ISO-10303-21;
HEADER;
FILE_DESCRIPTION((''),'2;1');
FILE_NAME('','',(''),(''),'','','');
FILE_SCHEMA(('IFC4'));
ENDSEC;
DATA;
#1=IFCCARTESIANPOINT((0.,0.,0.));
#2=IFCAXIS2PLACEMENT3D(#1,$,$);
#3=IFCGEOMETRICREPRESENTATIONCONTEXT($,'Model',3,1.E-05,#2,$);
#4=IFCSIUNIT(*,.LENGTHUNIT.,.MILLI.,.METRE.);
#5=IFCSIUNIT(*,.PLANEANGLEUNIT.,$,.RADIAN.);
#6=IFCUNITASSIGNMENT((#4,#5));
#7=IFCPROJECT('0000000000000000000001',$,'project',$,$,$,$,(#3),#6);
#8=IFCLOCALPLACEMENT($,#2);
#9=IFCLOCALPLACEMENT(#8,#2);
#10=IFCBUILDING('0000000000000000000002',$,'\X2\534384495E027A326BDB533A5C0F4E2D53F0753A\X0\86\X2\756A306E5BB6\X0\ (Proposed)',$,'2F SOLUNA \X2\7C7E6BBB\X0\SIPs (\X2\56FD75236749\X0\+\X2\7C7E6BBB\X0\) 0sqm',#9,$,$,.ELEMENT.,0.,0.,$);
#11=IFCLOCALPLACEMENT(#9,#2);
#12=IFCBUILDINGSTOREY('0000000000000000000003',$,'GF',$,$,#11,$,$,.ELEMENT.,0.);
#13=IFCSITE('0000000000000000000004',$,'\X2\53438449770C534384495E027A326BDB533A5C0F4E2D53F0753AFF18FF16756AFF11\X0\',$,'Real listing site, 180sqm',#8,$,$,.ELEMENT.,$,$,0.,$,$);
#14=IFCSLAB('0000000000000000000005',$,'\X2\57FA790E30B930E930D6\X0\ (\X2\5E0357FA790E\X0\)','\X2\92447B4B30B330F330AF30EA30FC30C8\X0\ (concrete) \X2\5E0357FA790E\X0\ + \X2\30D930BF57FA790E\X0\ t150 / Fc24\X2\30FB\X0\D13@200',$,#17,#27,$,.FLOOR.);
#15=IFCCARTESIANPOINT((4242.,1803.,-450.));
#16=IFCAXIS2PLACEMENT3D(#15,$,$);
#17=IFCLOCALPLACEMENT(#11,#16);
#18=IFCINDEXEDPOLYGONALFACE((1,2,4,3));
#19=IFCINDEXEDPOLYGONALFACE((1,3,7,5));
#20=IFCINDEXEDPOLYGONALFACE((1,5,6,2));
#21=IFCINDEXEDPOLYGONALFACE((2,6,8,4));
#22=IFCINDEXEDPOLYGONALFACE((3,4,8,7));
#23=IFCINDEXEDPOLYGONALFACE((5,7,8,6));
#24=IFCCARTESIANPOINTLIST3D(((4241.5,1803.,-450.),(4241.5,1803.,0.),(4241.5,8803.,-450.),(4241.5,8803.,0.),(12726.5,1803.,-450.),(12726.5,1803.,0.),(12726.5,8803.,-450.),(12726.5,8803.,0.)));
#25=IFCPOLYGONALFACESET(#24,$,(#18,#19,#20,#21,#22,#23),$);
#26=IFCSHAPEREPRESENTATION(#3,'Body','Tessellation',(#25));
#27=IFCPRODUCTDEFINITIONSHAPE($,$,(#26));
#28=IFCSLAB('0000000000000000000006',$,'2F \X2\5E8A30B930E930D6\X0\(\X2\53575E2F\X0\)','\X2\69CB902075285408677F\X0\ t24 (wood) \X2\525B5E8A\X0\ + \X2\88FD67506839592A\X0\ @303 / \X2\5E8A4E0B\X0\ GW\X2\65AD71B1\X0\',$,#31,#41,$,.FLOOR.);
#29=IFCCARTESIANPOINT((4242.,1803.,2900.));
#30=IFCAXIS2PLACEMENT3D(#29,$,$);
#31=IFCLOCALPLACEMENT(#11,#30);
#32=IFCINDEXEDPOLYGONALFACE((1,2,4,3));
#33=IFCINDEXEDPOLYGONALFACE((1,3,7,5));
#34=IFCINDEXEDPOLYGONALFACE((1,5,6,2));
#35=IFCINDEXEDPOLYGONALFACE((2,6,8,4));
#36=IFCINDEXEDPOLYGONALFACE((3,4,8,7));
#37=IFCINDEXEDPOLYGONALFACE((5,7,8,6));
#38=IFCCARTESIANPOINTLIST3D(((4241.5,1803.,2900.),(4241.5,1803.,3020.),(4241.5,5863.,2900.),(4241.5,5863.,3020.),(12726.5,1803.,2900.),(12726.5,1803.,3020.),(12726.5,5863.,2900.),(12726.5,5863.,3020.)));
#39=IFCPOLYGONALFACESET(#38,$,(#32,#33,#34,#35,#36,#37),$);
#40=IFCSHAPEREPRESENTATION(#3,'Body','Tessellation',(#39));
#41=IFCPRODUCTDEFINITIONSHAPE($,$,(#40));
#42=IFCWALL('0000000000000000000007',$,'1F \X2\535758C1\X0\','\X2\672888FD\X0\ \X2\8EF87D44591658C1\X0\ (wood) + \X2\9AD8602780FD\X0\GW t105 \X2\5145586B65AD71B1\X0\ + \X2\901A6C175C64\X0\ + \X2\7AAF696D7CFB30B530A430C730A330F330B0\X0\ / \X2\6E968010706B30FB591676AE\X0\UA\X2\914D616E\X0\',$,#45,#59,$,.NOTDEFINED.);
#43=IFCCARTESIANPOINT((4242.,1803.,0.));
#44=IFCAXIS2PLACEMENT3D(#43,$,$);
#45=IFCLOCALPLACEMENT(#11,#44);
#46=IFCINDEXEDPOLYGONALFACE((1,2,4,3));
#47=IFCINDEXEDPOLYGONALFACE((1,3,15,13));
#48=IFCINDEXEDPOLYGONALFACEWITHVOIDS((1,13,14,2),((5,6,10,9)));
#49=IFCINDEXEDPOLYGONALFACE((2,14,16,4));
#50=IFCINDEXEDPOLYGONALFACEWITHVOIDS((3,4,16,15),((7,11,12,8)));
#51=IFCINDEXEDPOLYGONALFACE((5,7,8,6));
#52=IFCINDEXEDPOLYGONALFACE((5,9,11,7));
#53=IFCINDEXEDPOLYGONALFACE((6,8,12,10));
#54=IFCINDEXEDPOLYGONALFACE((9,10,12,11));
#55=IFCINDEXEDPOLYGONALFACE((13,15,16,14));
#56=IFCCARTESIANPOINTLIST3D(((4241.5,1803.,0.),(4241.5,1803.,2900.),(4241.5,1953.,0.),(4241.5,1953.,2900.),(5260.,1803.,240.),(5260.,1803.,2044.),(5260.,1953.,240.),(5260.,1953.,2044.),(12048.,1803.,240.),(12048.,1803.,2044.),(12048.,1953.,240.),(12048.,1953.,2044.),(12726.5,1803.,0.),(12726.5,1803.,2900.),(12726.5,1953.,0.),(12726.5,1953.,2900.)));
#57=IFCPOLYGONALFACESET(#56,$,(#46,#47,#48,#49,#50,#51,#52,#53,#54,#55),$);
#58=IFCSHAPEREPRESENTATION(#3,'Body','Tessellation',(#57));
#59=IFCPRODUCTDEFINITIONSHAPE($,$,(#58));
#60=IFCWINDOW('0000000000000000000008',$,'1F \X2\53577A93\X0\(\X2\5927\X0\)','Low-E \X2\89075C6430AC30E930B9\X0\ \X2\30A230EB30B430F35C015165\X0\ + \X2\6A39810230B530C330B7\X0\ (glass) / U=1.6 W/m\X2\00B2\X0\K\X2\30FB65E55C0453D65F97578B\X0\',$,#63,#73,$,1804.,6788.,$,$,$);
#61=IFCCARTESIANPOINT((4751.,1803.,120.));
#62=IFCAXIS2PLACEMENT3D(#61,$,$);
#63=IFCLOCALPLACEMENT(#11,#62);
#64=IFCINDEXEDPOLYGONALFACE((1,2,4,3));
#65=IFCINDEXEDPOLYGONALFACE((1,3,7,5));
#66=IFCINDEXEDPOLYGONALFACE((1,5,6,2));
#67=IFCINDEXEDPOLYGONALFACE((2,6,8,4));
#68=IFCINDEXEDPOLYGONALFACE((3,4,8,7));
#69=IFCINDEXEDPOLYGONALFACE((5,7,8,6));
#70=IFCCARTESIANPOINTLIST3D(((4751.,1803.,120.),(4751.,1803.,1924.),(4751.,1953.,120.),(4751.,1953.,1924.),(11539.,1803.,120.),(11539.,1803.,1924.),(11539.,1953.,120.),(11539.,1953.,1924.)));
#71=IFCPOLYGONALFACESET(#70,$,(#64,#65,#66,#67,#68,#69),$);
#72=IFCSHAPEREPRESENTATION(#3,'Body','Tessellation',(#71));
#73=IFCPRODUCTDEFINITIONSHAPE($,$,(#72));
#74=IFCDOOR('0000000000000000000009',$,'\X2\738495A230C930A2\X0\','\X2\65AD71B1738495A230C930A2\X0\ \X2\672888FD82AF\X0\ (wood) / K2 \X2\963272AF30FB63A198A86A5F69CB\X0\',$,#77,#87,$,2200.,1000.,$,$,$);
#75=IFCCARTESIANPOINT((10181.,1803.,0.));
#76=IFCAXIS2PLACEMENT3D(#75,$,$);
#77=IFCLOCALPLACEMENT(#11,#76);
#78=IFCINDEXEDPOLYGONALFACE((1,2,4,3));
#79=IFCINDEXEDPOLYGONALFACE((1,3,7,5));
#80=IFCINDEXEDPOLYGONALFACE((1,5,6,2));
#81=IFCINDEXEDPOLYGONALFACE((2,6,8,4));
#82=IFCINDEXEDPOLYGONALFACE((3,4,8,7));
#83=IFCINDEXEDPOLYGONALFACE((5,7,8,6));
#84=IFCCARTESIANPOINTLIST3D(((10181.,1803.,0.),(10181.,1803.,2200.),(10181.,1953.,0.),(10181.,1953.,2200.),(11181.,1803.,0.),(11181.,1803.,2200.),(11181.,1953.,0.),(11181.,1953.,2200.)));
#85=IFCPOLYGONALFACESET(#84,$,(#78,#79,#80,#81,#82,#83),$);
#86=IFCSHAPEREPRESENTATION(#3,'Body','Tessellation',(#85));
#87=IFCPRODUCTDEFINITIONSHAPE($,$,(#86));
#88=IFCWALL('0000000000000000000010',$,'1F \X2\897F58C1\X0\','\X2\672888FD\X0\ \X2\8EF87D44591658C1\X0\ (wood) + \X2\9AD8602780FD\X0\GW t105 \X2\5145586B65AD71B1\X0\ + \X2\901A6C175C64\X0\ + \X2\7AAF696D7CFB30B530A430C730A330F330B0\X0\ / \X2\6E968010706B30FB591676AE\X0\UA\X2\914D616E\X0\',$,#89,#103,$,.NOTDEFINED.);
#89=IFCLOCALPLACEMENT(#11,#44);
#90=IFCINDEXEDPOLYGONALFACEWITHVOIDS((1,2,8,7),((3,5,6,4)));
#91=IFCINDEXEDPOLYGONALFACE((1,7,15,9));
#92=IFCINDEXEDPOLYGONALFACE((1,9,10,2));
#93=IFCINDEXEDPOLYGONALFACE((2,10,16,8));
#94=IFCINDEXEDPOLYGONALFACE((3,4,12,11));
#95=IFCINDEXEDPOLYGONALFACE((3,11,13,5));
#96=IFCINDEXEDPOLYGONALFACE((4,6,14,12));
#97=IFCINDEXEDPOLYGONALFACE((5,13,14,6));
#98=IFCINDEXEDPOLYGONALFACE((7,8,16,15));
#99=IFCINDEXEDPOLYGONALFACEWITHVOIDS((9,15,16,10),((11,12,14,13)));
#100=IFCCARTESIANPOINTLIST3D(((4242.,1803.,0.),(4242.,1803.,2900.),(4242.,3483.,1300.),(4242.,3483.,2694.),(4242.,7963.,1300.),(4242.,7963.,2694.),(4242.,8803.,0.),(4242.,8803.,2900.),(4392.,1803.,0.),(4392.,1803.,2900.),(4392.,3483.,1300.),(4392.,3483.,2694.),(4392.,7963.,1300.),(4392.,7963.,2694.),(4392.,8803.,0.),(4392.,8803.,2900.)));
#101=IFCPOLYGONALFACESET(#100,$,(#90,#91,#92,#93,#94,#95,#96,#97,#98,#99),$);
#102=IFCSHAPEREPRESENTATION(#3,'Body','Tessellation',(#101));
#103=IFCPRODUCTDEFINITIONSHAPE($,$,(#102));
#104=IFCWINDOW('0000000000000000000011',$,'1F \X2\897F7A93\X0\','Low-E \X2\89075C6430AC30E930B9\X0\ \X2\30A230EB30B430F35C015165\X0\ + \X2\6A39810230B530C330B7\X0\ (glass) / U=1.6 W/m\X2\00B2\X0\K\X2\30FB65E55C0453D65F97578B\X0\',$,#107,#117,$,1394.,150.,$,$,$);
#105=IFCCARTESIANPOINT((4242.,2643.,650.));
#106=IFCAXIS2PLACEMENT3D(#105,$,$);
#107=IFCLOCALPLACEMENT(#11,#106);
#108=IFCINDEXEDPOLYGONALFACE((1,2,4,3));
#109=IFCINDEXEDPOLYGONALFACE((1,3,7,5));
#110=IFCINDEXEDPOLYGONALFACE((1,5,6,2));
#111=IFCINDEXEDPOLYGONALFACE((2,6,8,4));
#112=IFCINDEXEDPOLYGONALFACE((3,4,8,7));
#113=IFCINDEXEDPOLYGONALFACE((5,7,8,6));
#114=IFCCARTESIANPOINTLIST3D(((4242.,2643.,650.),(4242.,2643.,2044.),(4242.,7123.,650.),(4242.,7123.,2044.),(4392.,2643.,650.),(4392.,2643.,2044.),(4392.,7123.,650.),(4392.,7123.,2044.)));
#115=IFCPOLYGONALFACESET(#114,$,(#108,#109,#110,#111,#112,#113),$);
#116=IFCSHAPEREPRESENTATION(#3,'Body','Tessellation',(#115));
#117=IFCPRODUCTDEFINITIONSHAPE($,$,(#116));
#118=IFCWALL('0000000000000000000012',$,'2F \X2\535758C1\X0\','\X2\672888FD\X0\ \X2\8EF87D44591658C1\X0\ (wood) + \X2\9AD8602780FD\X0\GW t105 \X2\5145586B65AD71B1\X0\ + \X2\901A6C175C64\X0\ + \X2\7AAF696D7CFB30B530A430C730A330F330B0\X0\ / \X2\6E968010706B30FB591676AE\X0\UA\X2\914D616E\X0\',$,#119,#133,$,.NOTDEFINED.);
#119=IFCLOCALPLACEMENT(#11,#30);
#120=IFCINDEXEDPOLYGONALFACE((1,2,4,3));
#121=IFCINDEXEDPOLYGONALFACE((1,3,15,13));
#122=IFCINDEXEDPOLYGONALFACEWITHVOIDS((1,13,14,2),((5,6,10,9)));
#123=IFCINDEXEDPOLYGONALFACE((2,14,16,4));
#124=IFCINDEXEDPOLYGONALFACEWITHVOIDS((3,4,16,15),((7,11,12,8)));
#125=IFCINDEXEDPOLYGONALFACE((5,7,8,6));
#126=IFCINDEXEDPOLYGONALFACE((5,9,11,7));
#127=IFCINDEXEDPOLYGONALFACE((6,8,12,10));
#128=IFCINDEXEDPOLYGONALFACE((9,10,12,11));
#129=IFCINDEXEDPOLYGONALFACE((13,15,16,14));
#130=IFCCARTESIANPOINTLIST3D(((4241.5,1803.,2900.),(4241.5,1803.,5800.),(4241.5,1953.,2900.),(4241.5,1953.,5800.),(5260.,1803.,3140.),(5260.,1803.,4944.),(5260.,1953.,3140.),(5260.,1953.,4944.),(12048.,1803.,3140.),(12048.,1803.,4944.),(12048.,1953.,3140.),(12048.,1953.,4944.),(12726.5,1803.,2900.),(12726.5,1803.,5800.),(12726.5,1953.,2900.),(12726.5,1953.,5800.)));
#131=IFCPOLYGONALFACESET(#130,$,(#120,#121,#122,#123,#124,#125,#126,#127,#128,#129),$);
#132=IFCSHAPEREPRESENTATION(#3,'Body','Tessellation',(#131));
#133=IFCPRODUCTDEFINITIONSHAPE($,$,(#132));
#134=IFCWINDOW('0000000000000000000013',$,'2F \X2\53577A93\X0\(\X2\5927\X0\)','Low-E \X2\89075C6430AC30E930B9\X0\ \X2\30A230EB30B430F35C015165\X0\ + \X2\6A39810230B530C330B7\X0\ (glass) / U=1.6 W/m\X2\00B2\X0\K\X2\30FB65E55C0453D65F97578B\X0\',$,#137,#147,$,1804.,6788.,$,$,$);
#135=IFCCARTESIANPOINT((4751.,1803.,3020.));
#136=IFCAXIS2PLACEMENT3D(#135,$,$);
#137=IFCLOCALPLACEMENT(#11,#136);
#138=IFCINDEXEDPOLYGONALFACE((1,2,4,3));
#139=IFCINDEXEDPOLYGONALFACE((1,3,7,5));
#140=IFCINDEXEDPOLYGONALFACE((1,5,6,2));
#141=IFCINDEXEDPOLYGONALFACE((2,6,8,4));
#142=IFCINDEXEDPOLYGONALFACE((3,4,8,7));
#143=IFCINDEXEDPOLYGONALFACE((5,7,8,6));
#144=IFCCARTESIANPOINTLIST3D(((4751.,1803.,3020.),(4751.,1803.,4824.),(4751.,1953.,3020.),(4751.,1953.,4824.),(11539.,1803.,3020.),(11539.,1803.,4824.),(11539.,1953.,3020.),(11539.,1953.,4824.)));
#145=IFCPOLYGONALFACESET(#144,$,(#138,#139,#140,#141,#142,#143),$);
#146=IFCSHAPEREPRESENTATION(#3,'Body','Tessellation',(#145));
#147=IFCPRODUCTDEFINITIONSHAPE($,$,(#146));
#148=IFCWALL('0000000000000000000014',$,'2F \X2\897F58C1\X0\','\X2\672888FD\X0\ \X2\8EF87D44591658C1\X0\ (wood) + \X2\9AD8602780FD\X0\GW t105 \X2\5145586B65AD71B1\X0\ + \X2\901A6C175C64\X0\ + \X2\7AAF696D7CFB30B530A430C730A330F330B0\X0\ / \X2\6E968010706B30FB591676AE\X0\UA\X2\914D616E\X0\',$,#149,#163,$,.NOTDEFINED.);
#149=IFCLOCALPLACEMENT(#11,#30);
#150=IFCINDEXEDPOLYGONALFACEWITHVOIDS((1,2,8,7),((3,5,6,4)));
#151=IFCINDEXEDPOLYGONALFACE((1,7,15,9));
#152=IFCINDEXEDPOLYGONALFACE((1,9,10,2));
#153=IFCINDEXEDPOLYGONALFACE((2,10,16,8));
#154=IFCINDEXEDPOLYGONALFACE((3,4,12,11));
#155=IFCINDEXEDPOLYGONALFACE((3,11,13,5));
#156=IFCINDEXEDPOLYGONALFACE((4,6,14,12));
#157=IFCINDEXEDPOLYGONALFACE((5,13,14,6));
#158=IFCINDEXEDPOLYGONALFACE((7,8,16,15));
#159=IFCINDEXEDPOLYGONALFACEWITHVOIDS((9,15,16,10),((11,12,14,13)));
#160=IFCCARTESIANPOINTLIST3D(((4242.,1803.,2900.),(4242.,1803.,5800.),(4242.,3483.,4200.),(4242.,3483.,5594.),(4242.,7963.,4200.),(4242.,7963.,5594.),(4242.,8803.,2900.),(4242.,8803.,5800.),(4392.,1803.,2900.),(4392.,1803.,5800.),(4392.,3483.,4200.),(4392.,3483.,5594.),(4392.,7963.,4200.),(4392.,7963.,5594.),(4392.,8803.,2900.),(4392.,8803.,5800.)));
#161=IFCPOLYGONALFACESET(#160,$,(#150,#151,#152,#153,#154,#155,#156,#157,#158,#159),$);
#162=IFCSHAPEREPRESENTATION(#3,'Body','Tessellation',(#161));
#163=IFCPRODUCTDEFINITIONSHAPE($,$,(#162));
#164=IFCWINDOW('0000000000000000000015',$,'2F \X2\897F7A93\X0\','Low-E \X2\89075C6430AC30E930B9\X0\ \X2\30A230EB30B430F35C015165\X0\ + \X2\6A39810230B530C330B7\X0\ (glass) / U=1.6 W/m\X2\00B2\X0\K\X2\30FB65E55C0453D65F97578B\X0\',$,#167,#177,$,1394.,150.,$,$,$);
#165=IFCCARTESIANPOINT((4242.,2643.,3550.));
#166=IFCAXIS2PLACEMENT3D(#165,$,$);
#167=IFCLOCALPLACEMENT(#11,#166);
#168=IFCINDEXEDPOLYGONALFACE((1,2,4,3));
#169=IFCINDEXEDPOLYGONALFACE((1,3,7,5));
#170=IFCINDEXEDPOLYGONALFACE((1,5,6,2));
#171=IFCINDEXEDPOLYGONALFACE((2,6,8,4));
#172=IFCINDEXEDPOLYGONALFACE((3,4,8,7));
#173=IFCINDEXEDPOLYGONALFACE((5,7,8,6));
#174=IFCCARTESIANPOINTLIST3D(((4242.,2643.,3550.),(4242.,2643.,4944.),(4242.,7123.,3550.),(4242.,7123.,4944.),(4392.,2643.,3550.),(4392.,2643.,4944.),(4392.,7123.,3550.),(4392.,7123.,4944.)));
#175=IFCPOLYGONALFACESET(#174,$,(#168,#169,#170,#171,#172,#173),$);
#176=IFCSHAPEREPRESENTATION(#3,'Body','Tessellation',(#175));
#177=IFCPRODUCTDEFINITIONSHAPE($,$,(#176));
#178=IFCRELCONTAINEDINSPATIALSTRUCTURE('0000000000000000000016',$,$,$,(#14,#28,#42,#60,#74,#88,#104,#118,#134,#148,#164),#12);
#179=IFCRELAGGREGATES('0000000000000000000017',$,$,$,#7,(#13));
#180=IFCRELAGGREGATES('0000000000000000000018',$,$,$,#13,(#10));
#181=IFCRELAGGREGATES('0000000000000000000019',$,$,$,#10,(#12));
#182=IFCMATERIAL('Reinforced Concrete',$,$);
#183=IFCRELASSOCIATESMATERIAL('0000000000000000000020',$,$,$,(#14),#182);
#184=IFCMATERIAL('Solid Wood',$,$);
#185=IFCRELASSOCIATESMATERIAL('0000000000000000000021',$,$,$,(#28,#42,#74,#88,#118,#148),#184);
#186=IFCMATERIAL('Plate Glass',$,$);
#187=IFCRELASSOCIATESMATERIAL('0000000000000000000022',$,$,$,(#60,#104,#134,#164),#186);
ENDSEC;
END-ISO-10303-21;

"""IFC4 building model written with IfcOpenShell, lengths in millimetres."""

from ifc_helpers import new_model, si_unit, frame, frame_2d, origin, place, context, project, spatial, rectangle, extrude, material, element, fill, save


model = new_model("IFC4")

# Units and contexts
model_context = context("Model", 3, precision=1e-05, world=origin())
ifc_project = project(units=[si_unit("LENGTHUNIT", "METRE", prefix="MILLI"), si_unit("PLANEANGLEUNIT", "RADIAN")], contexts=[model_context])

# Site, building, storey
site_placement = place(None, origin())
site = spatial("IfcSite", under=ifc_project, at=site_placement, Name="千葉県千葉市稲毛区小中台町８６番１", ObjectType="Real listing site, 180sqm", CompositionType="ELEMENT", RefElevation=0.0)
building_placement = place(site_placement, origin())
building = spatial("IfcBuilding", under=site, at=building_placement, Name="千葉市稲毛区小中台町86番の家 (Proposed)", ObjectType="2F SOLUNA 籾殻SIPs (国産杉+籾殻) 0sqm", CompositionType="ELEMENT", ElevationOfRefHeight=0.0, ElevationOfTerrain=0.0)
storey_placement = place(building_placement, origin())
storey = spatial("IfcBuildingStorey", under=building, at=storey_placement, Name="GF", CompositionType="ELEMENT", Elevation=0.0)

# Slabs
ifc_material_1 = material(Name="Reinforced Concrete")
slab_1_placement = place(storey_placement, frame((4242.0, 1803.0, -450.0)))
element("IfcSlab", 1, at=slab_1_placement, inside=storey, material=ifc_material_1, Name="基礎スラブ (布基礎)", Description="鉄筋コンクリート (concrete) 布基礎 + ベタ基礎 t150 / Fc24・D13@200", PredefinedType="FLOOR", context=model_context, shape_type="SweptSolid", body=[
    extrude(rectangle(XDim=8485.0, YDim=7000.0, at=frame_2d((4242.0, 3500.0))), frame((4242.0, 1803.0, -450.0)), (0.0, 0.0, 1.0), 450.0),
])
ifc_material_2 = material(Name="Solid Wood")
slab_2_placement = place(storey_placement, frame((4242.0, 1803.0, 2900.0)))
element("IfcSlab", 2, at=slab_2_placement, inside=storey, material=ifc_material_2, Name="2F 床スラブ(南帯)", Description="構造用合板 t24 (wood) 剛床 + 製材根太 @303 / 床下 GW断熱", PredefinedType="FLOOR", context=model_context, shape_type="SweptSolid", body=[
    extrude(rectangle(XDim=8485.0, YDim=4060.0, at=frame_2d((4242.0, 2030.0))), frame((4242.0, 1803.0, 2900.0)), (0.0, 0.0, 1.0), 120.0),
])

# Wall, openings, window, door
wall_1_placement = place(storey_placement, frame((4242.0, 1803.0, 0.0)))
wall_1 = element("IfcWall", 3, at=wall_1_placement, inside=storey, material=ifc_material_2, Name="1F 南壁", Description="木製 軸組外壁 (wood) + 高性能GW t105 充填断熱 + 通気層 + 窯業系サイディング / 準耐火・外皮UA配慮", PredefinedType="NOTDEFINED", context=model_context, shape_type="SweptSolid", body=[
    extrude(rectangle(XDim=8485.0, YDim=150.0, at=frame_2d((4242.0, 75.0))), frame((4242.0, 1803.0, 0.0)), (0.0, 0.0, 1.0), 2900.0),
])
opening_1_placement = place(storey_placement, frame((4751.0, 1803.0, 120.0)))
opening_1 = element("IfcOpeningElement", 4, at=opening_1_placement, cuts=wall_1, PredefinedType="NOTDEFINED", context=model_context, shape_type="SweptSolid", body=[
    extrude(rectangle(XDim=6788.0, YDim=150.0, at=frame_2d((3394.0, 75.0))), frame((4751.0, 1803.0, 120.0)), (0.0, 0.0, 1.0), 1804.0),
])
opening_2_placement = place(storey_placement, frame((10181.0, 1803.0, 0.0)))
opening_2 = element("IfcOpeningElement", 5, at=opening_2_placement, cuts=wall_1, PredefinedType="NOTDEFINED", context=model_context, shape_type="SweptSolid", body=[
    extrude(rectangle(XDim=1000.0, YDim=150.0, at=frame_2d((500.0, 75.0))), frame((10181.0, 1803.0, 0.0)), (0.0, 0.0, 1.0), 2200.0),
])
ifc_material_3 = material(Name="Plate Glass")
window_1_placement = place(storey_placement, frame((4751.0, 1803.0, 120.0)))
window_1 = element("IfcWindow", 6, at=window_1_placement, inside=storey, material=ifc_material_3, Name="1F 南窓(大)", Description="Low-E 複層ガラス アルゴン封入 + 樹脂サッシ (glass) / U=1.6 W/m²K・日射取得型", OverallHeight=1804.0, OverallWidth=6788.0, context=model_context, shape_type="SweptSolid", body=[
    extrude(rectangle(XDim=6788.0, YDim=150.0, at=frame_2d((3394.0, 75.0))), frame((4751.0, 1803.0, 120.0)), (0.0, 0.0, 1.0), 1804.0),
])
fill(opening_1, window_1)
door_placement = place(storey_placement, frame((10181.0, 1803.0, 0.0)))
door = element("IfcDoor", 7, at=door_placement, inside=storey, material=ifc_material_2, Name="玄関ドア", Description="断熱玄関ドア 木製芯 (wood) / K2 防犯・採風機構", OverallHeight=2200.0, OverallWidth=1000.0, context=model_context, shape_type="SweptSolid", body=[
    extrude(rectangle(XDim=1000.0, YDim=150.0, at=frame_2d((500.0, 75.0))), frame((10181.0, 1803.0, 0.0)), (0.0, 0.0, 1.0), 2200.0),
])
fill(opening_2, door)

# Wall, opening, window
wall_2_placement = place(storey_placement, frame((4242.0, 1803.0, 0.0)))
wall_2 = element("IfcWall", 8, at=wall_2_placement, inside=storey, material=ifc_material_2, Name="1F 西壁", Description="木製 軸組外壁 (wood) + 高性能GW t105 充填断熱 + 通気層 + 窯業系サイディング / 準耐火・外皮UA配慮", PredefinedType="NOTDEFINED", context=model_context, shape_type="SweptSolid", body=[
    extrude(rectangle(XDim=150.0, YDim=7000.0, at=frame_2d((75.0, 3500.0))), frame((4242.0, 1803.0, 0.0)), (0.0, 0.0, 1.0), 2900.0),
])
opening_3_placement = place(storey_placement, frame((4242.0, 2643.0, 650.0)))
opening_3 = element("IfcOpeningElement", 9, at=opening_3_placement, cuts=wall_2, PredefinedType="NOTDEFINED", context=model_context, shape_type="SweptSolid", body=[
    extrude(rectangle(XDim=150.0, YDim=4480.0, at=frame_2d((75.0, 2240.0))), frame((4242.0, 2643.0, 650.0)), (0.0, 0.0, 1.0), 1394.0),
])
window_2_placement = place(storey_placement, frame((4242.0, 2643.0, 650.0)))
window_2 = element("IfcWindow", 10, at=window_2_placement, inside=storey, material=ifc_material_3, Name="1F 西窓", Description="Low-E 複層ガラス アルゴン封入 + 樹脂サッシ (glass) / U=1.6 W/m²K・日射取得型", OverallHeight=1394.0, OverallWidth=150.0, context=model_context, shape_type="SweptSolid", body=[
    extrude(rectangle(XDim=150.0, YDim=4480.0, at=frame_2d((75.0, 2240.0))), frame((4242.0, 2643.0, 650.0)), (0.0, 0.0, 1.0), 1394.0),
])
fill(opening_3, window_2)

# Walls, openings, windows
wall_3_placement = place(storey_placement, frame((4242.0, 1803.0, 2900.0)))
wall_3 = element("IfcWall", 11, at=wall_3_placement, inside=storey, material=ifc_material_2, Name="2F 南壁", Description="木製 軸組外壁 (wood) + 高性能GW t105 充填断熱 + 通気層 + 窯業系サイディング / 準耐火・外皮UA配慮", PredefinedType="NOTDEFINED", context=model_context, shape_type="SweptSolid", body=[
    extrude(rectangle(XDim=8485.0, YDim=150.0, at=frame_2d((4242.0, 75.0))), frame((4242.0, 1803.0, 2900.0)), (0.0, 0.0, 1.0), 2900.0),
])
opening_4_placement = place(storey_placement, frame((4751.0, 1803.0, 3020.0)))
opening_4 = element("IfcOpeningElement", 12, at=opening_4_placement, cuts=wall_3, PredefinedType="NOTDEFINED", context=model_context, shape_type="SweptSolid", body=[
    extrude(rectangle(XDim=6788.0, YDim=150.0, at=frame_2d((3394.0, 75.0))), frame((4751.0, 1803.0, 3020.0)), (0.0, 0.0, 1.0), 1804.0),
])
window_3_placement = place(storey_placement, frame((4751.0, 1803.0, 3020.0)))
window_3 = element("IfcWindow", 13, at=window_3_placement, inside=storey, material=ifc_material_3, Name="2F 南窓(大)", Description="Low-E 複層ガラス アルゴン封入 + 樹脂サッシ (glass) / U=1.6 W/m²K・日射取得型", OverallHeight=1804.0, OverallWidth=6788.0, context=model_context, shape_type="SweptSolid", body=[
    extrude(rectangle(XDim=6788.0, YDim=150.0, at=frame_2d((3394.0, 75.0))), frame((4751.0, 1803.0, 3020.0)), (0.0, 0.0, 1.0), 1804.0),
])
fill(opening_4, window_3)
wall_4_placement = place(storey_placement, frame((4242.0, 1803.0, 2900.0)))
wall_4 = element("IfcWall", 14, at=wall_4_placement, inside=storey, material=ifc_material_2, Name="2F 西壁", Description="木製 軸組外壁 (wood) + 高性能GW t105 充填断熱 + 通気層 + 窯業系サイディング / 準耐火・外皮UA配慮", PredefinedType="NOTDEFINED", context=model_context, shape_type="SweptSolid", body=[
    extrude(rectangle(XDim=150.0, YDim=7000.0, at=frame_2d((75.0, 3500.0))), frame((4242.0, 1803.0, 2900.0)), (0.0, 0.0, 1.0), 2900.0),
])
opening_5_placement = place(storey_placement, frame((4242.0, 2643.0, 3550.0)))
opening_5 = element("IfcOpeningElement", 15, at=opening_5_placement, cuts=wall_4, PredefinedType="NOTDEFINED", context=model_context, shape_type="SweptSolid", body=[
    extrude(rectangle(XDim=150.0, YDim=4480.0, at=frame_2d((75.0, 2240.0))), frame((4242.0, 2643.0, 3550.0)), (0.0, 0.0, 1.0), 1394.0),
])
window_4_placement = place(storey_placement, frame((4242.0, 2643.0, 3550.0)))
window_4 = element("IfcWindow", 16, at=window_4_placement, inside=storey, material=ifc_material_3, Name="2F 西窓", Description="Low-E 複層ガラス アルゴン封入 + 樹脂サッシ (glass) / U=1.6 W/m²K・日射取得型", OverallHeight=1394.0, OverallWidth=150.0, context=model_context, shape_type="SweptSolid", body=[
    extrude(rectangle(XDim=150.0, YDim=4480.0, at=frame_2d((75.0, 2240.0))), frame((4242.0, 2643.0, 3550.0)), (0.0, 0.0, 1.0), 1394.0),
])
fill(opening_5, window_4)

save(model, "model.ifc")
